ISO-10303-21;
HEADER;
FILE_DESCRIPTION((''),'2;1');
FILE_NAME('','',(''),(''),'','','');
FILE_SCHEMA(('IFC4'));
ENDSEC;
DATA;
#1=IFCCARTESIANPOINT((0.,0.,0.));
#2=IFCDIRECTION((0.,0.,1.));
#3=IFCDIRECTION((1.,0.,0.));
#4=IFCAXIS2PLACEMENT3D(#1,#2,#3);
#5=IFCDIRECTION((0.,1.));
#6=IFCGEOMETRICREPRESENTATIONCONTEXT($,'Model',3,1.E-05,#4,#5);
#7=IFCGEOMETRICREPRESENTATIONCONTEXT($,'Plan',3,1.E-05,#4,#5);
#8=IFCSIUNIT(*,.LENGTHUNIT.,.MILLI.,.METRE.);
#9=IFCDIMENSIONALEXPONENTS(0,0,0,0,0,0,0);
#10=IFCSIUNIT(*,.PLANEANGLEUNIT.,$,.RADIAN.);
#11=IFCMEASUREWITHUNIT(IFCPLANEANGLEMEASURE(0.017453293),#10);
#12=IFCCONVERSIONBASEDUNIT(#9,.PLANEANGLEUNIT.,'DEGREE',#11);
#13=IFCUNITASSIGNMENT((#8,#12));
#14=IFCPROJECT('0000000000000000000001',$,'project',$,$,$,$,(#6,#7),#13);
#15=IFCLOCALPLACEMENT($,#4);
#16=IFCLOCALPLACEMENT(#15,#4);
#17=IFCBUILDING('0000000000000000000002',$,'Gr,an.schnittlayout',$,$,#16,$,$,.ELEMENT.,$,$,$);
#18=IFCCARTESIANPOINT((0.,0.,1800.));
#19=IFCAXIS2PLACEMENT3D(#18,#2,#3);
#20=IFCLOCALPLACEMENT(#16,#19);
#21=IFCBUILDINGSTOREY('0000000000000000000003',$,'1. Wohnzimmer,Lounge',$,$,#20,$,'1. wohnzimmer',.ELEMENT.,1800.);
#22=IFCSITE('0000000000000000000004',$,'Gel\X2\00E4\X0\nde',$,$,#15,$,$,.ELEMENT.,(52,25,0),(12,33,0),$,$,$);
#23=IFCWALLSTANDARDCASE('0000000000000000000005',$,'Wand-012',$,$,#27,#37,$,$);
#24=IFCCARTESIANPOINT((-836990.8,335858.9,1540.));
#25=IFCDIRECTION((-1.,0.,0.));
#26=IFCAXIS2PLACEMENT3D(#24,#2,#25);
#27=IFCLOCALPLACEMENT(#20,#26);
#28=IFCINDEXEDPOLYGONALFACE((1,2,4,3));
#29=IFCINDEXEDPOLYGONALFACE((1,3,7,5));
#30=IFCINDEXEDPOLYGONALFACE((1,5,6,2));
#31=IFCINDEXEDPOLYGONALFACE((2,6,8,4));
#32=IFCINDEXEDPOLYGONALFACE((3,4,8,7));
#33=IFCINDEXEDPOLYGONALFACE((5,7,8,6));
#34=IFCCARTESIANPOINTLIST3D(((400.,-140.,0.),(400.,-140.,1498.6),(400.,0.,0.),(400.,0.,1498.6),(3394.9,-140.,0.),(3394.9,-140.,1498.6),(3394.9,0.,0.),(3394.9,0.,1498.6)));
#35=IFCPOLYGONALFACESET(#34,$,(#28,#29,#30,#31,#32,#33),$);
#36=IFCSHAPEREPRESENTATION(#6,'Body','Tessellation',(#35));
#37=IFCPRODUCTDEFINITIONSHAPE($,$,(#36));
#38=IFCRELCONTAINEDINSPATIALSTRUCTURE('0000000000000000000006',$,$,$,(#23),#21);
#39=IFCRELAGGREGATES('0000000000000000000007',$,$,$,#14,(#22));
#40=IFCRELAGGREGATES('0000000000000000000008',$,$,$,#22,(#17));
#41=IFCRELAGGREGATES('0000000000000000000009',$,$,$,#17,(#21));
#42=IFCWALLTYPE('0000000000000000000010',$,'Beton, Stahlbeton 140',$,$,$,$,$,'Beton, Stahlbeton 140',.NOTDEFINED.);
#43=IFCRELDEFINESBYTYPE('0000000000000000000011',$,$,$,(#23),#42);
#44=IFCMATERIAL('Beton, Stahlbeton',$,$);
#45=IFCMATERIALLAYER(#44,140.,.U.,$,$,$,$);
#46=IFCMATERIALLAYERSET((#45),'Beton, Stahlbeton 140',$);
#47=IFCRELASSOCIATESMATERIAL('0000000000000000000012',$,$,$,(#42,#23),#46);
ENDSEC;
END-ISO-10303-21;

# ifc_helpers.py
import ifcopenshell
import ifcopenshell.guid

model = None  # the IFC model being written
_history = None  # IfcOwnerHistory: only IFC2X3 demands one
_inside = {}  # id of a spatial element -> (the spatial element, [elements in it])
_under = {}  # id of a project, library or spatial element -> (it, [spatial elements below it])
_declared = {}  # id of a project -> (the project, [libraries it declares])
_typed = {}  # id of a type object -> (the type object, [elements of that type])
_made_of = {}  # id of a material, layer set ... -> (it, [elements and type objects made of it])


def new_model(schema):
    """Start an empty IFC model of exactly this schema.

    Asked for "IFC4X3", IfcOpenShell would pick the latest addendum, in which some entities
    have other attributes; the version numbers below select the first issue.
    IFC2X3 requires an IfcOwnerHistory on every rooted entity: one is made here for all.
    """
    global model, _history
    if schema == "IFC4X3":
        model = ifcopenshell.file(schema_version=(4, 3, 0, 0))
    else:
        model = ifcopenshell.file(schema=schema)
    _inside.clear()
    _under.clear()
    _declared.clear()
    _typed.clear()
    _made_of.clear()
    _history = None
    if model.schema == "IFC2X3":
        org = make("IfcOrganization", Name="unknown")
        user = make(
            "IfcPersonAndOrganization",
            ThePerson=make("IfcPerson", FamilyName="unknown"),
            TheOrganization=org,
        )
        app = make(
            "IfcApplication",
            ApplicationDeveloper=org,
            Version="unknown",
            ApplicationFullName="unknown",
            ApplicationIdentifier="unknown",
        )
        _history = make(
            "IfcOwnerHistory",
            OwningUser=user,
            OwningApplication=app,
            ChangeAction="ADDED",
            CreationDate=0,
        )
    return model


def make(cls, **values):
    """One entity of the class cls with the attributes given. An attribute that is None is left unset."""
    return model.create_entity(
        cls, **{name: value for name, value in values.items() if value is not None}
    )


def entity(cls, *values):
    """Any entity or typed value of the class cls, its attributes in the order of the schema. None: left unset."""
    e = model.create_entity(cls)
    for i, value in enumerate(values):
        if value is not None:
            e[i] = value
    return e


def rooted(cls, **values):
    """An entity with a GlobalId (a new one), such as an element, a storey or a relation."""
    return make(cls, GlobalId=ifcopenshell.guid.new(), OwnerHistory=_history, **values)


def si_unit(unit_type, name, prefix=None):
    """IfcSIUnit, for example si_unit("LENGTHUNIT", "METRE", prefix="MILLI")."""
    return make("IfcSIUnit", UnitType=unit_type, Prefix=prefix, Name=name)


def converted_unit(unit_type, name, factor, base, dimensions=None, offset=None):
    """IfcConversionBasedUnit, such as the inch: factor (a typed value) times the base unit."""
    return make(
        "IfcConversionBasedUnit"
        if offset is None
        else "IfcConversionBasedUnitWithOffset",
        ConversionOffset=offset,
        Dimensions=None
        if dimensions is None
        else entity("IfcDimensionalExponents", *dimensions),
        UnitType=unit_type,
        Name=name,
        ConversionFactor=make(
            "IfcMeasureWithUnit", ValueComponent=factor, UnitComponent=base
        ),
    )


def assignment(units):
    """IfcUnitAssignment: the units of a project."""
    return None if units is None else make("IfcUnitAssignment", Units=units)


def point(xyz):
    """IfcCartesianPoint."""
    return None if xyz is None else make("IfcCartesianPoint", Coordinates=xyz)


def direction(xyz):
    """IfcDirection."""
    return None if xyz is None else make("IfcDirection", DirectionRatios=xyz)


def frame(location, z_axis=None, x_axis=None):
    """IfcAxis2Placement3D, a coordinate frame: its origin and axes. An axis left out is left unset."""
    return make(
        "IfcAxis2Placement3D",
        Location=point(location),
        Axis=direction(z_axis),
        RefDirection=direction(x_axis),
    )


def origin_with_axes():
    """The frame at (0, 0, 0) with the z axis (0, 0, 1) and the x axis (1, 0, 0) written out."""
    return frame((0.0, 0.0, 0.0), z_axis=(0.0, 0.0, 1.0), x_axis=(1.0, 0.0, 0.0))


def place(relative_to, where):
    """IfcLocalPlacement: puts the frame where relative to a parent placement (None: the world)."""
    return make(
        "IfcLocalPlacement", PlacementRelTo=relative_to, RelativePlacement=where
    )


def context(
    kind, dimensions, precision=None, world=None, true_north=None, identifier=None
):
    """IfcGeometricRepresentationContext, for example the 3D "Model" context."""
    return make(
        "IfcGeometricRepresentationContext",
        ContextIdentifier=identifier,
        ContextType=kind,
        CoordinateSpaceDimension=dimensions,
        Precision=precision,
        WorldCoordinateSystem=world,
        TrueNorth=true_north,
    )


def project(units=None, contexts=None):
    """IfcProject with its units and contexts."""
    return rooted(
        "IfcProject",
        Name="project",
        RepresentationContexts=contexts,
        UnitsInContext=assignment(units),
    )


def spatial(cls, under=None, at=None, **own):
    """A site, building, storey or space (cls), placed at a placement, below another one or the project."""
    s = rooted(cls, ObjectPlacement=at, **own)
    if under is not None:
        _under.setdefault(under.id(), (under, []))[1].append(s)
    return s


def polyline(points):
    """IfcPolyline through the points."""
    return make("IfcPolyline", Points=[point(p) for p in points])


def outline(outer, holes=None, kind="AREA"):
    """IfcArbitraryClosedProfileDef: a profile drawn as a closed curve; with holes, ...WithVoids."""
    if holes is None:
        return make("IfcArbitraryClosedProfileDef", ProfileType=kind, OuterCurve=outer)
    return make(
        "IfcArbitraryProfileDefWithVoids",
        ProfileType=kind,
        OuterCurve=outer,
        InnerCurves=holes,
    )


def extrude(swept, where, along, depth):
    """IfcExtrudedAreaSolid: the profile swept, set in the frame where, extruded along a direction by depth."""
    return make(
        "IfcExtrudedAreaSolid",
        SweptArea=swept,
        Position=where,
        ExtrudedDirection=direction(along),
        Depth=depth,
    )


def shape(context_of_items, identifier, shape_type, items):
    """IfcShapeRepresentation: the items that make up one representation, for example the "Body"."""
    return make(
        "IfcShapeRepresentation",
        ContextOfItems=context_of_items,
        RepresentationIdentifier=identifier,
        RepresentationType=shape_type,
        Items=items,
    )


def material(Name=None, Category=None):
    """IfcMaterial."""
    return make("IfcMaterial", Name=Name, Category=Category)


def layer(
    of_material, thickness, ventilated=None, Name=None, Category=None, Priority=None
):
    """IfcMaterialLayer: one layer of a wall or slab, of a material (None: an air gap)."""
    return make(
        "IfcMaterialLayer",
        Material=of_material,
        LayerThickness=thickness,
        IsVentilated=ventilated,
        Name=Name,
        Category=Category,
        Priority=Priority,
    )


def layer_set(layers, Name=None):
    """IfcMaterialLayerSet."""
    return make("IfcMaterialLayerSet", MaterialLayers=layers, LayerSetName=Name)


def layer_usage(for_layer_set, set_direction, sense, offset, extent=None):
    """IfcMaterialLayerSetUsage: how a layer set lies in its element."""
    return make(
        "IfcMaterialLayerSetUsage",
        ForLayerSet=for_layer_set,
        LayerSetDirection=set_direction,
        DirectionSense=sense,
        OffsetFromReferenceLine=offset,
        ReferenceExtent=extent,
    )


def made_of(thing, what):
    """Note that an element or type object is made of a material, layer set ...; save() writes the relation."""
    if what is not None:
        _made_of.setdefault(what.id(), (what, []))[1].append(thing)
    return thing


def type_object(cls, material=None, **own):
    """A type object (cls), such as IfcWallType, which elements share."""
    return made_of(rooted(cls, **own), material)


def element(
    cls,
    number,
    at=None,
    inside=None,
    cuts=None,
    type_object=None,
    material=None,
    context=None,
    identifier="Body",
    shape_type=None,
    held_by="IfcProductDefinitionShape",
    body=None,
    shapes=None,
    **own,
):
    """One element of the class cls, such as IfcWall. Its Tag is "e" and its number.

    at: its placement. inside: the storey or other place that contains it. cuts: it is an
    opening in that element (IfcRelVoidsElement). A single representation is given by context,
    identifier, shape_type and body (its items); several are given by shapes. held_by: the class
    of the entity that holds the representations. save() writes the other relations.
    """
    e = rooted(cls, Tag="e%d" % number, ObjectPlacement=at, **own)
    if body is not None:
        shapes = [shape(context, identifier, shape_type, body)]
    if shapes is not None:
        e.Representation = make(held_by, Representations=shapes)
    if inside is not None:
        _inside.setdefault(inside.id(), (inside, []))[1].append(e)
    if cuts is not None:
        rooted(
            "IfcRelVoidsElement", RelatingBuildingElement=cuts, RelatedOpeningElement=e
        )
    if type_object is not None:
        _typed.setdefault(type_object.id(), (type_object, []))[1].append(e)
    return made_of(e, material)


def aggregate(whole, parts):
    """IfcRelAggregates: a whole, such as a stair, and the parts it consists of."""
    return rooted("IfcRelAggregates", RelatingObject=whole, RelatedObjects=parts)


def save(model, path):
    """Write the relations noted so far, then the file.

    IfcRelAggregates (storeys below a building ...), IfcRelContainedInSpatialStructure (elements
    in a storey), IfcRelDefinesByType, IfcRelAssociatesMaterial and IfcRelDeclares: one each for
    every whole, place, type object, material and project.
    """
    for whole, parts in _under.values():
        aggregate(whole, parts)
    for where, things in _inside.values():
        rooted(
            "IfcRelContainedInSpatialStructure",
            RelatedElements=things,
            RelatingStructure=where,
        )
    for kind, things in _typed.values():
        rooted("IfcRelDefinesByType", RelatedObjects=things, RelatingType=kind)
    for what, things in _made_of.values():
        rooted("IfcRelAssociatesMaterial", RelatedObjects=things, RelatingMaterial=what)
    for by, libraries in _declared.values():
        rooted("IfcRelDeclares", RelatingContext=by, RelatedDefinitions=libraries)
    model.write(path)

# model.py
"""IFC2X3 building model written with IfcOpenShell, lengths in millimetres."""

from ifc_helpers import new_model, entity, si_unit, converted_unit, direction, frame, origin_with_axes, place, context, project, spatial, polyline, outline, extrude, material, layer, layer_set, layer_usage, type_object, element, save


model = new_model("IFC2X3")

# Units and contexts
model_context = context("Model", 3, precision=1e-05, world=origin_with_axes(), true_north=direction((0.0, 1.0)))
plan_context = context("Plan", 3, precision=1e-05, world=origin_with_axes(), true_north=direction((0.0, 1.0)))
ifc_project = project(units=[si_unit("LENGTHUNIT", "METRE", prefix="MILLI"), converted_unit("PLANEANGLEUNIT", "DEGREE", entity("IfcPlaneAngleMeasure", 0.017453293), si_unit("PLANEANGLEUNIT", "RADIAN"), dimensions=[0, 0, 0, 0, 0, 0, 0])], contexts=[model_context, plan_context])

# Site, building, storey
site_placement = place(None, origin_with_axes())
site = spatial("IfcSite", under=ifc_project, at=site_placement, Name="Gelände", CompositionType="ELEMENT", RefLatitude=(52, 25, 0), RefLongitude=(12, 33, 0))
building_placement = place(site_placement, origin_with_axes())
building = spatial("IfcBuilding", under=site, at=building_placement, Name="Gr,an.schnittlayout", CompositionType="ELEMENT")
storey_placement = place(building_placement, frame((0.0, 0.0, 1800.0), z_axis=(0.0, 0.0, 1.0), x_axis=(1.0, 0.0, 0.0)))
storey = spatial("IfcBuildingStorey", under=building, at=storey_placement, Name="1. Wohnzimmer,Lounge", LongName="1. wohnzimmer", CompositionType="ELEMENT", Elevation=1800.0)

# Shared definitions
ifc_material = material(Name="Beton, Stahlbeton")

# Wall
ifc_layer_1 = layer(ifc_material, 140.0, ventilated="UNKNOWN")
ifc_layer_set_1 = layer_set([ifc_layer_1], Name="Beton, Stahlbeton 140")
ifc_layer_usage_1 = layer_usage(ifc_layer_set_1, "AXIS2", "NEGATIVE", 0.0)
wall_type = type_object("IfcWallType", Name="Beton, Stahlbeton 140", ElementType="Beton, Stahlbeton 140", PredefinedType="NOTDEFINED", material=ifc_layer_set_1)
wall_placement = place(storey_placement, frame((-836990.8, 335858.9, 1540.0), z_axis=(0.0, 0.0, 1.0), x_axis=(-1.0, 0.0, 0.0)))
element("IfcWallStandardCase", 1, at=wall_placement, inside=storey, type_object=wall_type, material=ifc_layer_usage_1, Name="Wand-012", context=model_context, shape_type="SweptSolid", body=[
    extrude(outline(polyline([(400.0, -140.0), (3394.9, -140.0), (3394.9, 0.0), (400.0, 0.0), (400.0, -140.0)])), origin_with_axes(), (0.0, 0.0, 1.0), 1498.6),
])

save(model, "model.ifc")
